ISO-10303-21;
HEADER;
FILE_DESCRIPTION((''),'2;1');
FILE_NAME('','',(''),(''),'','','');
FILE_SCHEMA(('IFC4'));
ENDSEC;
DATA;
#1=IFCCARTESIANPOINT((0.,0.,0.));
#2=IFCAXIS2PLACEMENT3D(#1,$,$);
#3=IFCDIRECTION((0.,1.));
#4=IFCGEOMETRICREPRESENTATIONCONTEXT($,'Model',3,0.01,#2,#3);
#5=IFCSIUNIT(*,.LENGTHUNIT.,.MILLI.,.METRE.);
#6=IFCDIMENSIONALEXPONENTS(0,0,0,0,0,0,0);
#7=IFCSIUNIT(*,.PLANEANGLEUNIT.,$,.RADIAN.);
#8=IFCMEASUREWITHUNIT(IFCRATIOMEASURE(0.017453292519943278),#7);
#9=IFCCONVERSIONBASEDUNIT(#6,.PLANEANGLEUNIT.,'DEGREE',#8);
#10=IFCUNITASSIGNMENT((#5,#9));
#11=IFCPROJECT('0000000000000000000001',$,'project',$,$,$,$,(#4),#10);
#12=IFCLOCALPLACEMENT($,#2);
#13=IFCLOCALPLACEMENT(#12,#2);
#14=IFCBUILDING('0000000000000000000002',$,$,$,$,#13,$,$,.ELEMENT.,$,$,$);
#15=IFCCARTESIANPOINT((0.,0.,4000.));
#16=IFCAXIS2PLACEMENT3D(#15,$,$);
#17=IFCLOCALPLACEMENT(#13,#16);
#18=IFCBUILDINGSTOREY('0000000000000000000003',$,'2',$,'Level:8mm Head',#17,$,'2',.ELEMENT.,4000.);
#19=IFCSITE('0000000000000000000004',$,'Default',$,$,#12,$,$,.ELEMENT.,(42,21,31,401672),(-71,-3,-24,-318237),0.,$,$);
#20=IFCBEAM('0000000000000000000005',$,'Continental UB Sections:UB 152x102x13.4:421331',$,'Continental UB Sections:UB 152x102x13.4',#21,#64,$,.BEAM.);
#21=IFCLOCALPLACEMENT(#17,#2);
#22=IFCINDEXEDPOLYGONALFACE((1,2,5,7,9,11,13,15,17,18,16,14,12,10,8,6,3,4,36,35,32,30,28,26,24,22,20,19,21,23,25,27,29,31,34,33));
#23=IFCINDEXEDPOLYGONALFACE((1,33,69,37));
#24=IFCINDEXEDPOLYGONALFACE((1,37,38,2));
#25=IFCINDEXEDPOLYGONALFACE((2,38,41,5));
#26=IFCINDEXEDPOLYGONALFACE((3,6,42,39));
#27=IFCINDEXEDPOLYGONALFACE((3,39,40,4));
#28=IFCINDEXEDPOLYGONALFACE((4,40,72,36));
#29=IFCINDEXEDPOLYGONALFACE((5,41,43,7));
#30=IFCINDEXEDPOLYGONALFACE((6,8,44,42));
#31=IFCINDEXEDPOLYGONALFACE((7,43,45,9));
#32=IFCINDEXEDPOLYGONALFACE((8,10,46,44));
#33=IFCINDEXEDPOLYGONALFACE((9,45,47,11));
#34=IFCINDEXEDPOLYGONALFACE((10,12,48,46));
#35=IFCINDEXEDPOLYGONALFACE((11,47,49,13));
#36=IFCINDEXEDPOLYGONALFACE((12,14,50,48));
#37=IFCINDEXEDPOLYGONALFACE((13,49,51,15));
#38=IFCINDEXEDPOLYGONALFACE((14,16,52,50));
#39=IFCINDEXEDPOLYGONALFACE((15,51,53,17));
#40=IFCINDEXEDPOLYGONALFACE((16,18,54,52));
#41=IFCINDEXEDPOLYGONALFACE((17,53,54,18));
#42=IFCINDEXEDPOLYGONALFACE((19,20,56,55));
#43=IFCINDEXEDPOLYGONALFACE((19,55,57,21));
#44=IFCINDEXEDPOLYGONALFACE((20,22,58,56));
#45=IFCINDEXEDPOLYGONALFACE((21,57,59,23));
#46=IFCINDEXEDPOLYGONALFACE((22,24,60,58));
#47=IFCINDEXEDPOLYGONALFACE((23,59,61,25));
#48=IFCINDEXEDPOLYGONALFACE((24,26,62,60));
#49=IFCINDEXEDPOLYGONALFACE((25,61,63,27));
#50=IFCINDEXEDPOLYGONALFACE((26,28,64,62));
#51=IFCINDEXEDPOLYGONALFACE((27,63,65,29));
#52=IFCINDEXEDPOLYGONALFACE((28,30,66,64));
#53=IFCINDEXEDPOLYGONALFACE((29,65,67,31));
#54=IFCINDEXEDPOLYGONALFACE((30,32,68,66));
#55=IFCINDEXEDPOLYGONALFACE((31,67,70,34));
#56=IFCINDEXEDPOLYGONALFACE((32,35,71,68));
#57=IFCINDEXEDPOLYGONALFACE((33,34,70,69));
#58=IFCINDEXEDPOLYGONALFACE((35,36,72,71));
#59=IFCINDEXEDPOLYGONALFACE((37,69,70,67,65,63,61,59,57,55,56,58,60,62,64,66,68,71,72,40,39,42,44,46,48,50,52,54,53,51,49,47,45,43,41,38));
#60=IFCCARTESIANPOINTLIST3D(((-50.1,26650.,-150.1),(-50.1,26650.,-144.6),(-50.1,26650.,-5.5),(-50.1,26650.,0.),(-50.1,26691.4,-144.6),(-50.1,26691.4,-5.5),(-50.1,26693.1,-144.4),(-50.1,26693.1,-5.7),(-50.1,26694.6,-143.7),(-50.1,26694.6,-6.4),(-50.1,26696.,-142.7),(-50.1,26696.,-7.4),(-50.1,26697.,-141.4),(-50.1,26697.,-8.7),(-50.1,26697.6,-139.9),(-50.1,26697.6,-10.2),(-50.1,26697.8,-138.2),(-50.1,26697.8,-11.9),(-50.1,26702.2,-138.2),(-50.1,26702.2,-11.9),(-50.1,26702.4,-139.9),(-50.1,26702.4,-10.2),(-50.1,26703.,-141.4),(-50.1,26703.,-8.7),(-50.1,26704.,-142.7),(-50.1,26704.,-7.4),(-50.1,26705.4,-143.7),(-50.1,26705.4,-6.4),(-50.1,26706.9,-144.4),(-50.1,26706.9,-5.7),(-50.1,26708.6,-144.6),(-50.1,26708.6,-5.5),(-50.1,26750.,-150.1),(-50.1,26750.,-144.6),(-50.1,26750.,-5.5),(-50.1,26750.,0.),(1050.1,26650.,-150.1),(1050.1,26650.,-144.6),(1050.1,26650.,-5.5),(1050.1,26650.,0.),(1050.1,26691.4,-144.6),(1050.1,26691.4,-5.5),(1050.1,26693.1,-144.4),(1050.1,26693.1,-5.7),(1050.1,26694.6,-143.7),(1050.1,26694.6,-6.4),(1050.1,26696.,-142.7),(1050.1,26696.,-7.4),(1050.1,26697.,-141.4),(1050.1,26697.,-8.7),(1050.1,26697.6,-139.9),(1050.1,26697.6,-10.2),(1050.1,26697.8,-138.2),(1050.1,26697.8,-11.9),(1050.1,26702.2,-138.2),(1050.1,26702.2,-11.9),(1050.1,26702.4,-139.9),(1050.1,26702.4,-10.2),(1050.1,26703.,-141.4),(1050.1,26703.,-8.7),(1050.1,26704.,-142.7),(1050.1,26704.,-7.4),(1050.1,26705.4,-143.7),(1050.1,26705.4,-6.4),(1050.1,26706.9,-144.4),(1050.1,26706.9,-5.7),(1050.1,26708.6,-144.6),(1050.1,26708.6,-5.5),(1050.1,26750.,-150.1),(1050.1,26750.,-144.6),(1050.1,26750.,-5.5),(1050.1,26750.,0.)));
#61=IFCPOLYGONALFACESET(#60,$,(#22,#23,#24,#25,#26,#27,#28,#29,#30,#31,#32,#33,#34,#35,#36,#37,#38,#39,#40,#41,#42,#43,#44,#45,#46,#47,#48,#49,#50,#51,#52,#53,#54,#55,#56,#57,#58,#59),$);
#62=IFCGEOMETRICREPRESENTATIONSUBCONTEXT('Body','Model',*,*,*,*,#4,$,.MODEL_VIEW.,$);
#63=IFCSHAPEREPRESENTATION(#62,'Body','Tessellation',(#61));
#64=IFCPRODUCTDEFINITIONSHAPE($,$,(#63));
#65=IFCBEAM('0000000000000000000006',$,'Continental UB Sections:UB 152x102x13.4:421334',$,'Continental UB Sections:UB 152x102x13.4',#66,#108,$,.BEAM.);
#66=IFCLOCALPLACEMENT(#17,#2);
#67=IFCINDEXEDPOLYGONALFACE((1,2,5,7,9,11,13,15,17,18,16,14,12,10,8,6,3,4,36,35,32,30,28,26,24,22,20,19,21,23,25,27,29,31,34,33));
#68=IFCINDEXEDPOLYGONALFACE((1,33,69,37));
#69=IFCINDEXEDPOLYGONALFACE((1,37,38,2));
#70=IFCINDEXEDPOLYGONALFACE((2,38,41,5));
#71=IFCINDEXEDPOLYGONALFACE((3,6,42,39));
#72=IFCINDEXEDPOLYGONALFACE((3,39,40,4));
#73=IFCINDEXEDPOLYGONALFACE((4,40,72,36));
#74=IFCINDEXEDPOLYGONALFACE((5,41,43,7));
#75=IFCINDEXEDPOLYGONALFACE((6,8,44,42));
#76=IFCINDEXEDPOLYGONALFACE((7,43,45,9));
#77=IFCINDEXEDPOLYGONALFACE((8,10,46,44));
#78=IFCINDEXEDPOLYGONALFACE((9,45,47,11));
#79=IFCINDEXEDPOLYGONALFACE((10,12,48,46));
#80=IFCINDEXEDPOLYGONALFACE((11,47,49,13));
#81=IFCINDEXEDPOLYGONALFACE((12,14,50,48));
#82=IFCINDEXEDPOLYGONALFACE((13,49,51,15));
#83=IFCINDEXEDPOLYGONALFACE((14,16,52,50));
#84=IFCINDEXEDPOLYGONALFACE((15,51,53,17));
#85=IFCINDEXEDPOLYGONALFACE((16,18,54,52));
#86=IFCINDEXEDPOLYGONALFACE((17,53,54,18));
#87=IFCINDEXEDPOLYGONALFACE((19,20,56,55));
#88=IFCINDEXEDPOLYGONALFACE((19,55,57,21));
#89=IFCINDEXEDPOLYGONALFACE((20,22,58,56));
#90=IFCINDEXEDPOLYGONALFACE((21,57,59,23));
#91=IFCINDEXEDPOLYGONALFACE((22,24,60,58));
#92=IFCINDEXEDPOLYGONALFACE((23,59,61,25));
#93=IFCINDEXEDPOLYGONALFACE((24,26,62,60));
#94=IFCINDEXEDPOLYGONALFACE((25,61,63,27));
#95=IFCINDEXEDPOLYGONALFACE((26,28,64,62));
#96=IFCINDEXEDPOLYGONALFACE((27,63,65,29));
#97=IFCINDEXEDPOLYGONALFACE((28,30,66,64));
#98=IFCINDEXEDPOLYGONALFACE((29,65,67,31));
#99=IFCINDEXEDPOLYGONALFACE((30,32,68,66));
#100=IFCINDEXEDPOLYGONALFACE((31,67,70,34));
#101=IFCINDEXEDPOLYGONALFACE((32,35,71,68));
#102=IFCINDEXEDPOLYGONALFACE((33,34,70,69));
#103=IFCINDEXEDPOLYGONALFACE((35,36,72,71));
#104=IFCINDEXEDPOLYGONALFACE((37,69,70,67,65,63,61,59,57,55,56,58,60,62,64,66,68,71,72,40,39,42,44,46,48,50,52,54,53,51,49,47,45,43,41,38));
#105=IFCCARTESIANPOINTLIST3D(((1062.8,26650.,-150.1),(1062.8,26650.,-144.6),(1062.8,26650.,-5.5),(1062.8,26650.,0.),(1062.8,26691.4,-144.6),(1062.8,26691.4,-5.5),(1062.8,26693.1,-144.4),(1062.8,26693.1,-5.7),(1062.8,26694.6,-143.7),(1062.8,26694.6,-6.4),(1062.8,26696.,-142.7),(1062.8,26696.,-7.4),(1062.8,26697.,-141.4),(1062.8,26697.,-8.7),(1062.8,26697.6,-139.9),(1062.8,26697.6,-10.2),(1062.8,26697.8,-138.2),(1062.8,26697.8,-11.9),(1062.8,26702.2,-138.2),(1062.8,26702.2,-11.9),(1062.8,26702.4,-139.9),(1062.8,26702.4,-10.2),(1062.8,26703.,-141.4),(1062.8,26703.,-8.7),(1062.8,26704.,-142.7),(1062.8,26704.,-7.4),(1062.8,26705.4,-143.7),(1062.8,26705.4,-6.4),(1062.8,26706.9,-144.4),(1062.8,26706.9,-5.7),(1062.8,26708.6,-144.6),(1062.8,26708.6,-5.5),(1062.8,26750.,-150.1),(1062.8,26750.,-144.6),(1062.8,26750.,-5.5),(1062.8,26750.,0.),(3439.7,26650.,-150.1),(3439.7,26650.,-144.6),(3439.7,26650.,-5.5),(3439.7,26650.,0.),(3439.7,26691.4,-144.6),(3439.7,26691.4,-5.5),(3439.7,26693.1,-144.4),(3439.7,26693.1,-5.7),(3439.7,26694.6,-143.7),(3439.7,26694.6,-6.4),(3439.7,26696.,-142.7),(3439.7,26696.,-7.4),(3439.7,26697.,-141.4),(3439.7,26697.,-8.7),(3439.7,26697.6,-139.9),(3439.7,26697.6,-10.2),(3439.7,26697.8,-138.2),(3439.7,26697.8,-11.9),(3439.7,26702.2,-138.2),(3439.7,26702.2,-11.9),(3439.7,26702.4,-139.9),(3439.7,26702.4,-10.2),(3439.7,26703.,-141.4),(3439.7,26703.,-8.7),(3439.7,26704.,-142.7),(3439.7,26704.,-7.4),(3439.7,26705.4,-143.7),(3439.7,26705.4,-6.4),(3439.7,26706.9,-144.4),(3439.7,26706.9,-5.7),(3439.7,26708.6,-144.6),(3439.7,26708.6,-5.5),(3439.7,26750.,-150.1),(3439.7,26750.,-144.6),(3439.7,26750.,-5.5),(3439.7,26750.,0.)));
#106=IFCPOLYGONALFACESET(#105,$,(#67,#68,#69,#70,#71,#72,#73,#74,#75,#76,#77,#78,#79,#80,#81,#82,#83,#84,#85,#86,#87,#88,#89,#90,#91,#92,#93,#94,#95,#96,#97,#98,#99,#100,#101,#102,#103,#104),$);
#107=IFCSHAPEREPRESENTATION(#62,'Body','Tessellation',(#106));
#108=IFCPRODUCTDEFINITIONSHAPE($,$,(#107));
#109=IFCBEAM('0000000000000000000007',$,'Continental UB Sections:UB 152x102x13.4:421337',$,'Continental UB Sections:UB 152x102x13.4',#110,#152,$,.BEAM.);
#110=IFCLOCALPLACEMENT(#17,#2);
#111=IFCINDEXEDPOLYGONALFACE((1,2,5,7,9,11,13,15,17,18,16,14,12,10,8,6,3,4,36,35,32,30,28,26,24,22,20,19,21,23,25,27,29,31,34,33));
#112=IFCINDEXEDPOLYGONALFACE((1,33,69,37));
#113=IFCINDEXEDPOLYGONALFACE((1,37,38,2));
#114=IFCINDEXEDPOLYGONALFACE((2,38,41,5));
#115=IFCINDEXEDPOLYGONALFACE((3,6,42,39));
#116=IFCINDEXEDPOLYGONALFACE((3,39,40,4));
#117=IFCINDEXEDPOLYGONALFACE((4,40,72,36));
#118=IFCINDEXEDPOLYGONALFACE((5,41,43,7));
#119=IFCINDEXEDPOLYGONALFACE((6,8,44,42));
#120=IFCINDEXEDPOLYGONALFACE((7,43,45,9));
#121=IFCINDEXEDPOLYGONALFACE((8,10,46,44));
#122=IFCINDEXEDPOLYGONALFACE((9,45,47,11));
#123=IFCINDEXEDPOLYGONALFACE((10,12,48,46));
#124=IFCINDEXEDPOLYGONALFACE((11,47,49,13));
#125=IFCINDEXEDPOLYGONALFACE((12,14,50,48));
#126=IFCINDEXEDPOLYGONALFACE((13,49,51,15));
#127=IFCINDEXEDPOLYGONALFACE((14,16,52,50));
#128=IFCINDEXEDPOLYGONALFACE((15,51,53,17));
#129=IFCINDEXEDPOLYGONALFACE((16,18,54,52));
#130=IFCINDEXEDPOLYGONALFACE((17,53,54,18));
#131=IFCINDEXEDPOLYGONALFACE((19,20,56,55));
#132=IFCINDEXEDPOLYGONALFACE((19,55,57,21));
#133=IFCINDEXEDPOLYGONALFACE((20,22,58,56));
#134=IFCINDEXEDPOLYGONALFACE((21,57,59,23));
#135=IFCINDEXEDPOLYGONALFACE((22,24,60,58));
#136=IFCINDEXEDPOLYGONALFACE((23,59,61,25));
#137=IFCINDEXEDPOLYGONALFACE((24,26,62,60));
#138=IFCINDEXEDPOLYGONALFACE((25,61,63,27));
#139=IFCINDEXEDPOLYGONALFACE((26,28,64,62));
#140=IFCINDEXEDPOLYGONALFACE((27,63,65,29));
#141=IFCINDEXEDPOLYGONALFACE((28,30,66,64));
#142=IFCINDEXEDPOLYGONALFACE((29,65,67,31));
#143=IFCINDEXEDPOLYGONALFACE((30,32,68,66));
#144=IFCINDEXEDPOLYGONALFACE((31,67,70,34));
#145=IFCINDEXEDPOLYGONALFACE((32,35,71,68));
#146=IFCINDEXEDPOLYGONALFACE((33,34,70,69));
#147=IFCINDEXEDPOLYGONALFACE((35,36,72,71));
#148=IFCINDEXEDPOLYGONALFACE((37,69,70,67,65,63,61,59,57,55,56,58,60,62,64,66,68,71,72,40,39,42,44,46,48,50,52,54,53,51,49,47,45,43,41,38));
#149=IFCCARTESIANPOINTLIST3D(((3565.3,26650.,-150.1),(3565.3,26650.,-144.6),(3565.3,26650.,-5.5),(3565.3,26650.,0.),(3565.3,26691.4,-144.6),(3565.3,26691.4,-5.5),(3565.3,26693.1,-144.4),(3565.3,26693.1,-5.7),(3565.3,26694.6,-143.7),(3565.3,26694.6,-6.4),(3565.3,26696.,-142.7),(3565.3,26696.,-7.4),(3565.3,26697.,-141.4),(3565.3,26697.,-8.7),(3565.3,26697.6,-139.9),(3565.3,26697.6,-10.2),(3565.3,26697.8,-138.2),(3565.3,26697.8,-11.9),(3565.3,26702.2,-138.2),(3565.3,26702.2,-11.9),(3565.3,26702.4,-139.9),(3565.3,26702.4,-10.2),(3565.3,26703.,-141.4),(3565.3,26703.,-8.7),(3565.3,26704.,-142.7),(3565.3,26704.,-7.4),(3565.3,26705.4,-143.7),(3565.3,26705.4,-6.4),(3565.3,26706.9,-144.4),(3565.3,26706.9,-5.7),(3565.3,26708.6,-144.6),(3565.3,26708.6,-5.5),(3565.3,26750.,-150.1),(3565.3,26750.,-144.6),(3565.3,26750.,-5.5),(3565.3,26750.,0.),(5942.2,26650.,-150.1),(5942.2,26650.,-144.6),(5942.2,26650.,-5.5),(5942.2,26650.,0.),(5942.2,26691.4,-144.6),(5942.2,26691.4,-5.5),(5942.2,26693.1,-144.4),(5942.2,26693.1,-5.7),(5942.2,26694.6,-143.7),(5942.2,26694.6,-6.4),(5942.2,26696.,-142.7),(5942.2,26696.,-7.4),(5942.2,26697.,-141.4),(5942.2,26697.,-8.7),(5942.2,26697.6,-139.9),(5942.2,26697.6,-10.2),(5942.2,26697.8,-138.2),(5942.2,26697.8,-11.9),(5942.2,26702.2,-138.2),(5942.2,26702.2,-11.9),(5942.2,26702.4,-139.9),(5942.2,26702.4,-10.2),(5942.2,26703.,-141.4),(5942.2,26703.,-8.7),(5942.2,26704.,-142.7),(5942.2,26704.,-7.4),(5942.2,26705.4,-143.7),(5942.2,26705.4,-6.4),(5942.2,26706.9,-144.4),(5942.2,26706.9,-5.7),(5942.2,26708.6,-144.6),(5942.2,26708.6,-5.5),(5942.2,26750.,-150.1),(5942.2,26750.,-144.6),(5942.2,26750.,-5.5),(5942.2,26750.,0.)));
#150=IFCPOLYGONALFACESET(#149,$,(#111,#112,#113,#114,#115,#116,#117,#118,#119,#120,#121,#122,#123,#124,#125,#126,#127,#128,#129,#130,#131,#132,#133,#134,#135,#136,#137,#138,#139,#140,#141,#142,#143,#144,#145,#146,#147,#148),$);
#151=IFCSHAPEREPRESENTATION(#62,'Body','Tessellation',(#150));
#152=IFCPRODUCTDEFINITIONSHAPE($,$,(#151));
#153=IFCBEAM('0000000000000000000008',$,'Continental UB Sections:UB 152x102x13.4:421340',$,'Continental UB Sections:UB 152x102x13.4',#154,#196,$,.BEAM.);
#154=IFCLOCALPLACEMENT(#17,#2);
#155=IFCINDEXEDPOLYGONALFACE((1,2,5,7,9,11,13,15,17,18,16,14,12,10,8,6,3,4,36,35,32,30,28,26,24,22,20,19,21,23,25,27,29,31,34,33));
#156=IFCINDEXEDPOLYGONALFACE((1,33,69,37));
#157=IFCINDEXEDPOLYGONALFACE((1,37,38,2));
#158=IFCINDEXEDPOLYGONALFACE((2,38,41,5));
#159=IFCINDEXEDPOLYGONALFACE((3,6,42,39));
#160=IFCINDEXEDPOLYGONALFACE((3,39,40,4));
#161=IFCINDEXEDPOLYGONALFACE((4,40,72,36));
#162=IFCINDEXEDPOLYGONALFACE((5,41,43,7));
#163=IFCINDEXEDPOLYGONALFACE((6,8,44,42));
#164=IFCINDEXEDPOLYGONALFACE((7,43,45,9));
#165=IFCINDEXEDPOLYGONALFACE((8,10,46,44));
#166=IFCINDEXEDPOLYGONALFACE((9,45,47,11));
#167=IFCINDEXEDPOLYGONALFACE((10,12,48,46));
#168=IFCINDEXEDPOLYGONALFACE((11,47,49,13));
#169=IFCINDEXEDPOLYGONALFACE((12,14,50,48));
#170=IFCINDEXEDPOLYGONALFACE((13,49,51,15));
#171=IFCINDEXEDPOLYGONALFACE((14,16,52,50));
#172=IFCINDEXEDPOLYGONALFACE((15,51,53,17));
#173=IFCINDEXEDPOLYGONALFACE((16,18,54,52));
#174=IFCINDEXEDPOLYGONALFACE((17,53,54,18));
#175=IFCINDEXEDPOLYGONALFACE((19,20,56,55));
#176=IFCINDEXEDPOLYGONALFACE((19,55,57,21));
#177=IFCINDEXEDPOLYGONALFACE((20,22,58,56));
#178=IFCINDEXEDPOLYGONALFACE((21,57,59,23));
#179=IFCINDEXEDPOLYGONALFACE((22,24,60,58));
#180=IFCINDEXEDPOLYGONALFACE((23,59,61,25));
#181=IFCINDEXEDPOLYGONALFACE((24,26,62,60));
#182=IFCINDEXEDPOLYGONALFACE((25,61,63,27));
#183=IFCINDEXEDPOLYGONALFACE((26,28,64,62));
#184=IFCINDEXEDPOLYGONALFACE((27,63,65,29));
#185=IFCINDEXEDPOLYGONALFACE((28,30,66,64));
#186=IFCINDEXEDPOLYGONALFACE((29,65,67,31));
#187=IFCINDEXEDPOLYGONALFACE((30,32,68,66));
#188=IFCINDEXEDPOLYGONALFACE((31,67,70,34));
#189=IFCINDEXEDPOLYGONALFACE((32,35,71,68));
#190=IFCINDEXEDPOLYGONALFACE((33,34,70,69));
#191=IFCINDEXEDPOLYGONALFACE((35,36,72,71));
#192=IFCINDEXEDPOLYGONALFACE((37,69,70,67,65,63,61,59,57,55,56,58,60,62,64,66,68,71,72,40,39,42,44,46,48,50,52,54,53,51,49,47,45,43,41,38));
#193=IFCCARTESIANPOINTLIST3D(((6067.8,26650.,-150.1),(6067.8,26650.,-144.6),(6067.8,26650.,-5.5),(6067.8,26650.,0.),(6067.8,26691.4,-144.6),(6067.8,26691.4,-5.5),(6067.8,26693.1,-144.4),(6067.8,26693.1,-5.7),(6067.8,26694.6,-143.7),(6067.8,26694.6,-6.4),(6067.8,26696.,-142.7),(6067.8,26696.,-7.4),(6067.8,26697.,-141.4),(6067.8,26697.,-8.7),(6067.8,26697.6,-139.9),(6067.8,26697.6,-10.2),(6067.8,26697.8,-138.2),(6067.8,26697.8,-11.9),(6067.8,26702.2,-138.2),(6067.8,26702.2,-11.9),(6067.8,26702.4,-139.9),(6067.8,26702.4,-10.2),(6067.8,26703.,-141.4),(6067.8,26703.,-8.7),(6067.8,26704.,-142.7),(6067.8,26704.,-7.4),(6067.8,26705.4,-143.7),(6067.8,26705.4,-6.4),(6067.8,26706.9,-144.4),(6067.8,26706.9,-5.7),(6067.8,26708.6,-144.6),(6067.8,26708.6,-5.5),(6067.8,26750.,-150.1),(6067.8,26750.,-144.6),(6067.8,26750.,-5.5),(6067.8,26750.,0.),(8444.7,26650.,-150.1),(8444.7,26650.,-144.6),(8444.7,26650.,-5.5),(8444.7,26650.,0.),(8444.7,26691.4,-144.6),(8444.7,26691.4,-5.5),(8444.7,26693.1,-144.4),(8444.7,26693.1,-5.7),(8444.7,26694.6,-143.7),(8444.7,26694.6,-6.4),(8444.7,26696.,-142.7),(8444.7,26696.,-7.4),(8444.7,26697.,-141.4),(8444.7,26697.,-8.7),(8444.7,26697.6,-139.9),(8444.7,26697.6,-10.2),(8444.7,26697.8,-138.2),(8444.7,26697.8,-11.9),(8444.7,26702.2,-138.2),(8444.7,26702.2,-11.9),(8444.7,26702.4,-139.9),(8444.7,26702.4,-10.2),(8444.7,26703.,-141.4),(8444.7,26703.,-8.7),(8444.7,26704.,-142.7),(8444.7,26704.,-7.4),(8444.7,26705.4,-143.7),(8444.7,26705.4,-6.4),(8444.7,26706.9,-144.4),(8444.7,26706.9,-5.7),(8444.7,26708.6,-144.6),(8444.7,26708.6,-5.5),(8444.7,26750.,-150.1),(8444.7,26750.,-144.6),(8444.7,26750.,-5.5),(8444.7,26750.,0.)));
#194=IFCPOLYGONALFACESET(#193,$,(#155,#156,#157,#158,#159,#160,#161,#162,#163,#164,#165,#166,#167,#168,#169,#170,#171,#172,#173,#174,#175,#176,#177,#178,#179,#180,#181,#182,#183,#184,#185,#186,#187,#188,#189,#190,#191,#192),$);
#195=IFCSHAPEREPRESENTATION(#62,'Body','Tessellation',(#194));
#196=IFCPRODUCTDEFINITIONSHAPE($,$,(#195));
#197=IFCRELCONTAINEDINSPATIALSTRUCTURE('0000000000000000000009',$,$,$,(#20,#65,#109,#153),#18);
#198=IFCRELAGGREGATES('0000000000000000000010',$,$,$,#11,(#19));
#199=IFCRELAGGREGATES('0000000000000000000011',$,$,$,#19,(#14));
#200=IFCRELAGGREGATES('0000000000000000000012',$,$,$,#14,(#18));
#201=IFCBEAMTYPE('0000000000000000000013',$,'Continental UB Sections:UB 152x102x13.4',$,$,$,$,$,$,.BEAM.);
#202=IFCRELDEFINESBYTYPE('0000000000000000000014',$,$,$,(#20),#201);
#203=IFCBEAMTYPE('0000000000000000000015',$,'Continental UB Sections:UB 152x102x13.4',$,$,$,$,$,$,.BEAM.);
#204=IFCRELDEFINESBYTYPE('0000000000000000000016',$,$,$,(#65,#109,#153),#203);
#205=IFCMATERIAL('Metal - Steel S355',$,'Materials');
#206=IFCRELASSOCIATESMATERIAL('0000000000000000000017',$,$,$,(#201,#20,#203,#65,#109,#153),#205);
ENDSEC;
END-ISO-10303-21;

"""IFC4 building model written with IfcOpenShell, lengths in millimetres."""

from ifc_helpers import new_model, entity, si_unit, converted_unit, direction, frame, origin, place, context, subcontext, project, spatial, line, arc, indexed_curve, outline, extrude, source, transform, mapped, material, type_object, type_shapes, element, save


model = new_model("IFC4")

# Units and contexts
model_context = context("Model", 3, precision=0.01, world=origin(), true_north=direction((0.0, 1.0)))
body_context = subcontext(model_context, "Body", "Model", "MODEL_VIEW")
ifc_project = project(units=[si_unit("LENGTHUNIT", "METRE", prefix="MILLI"), converted_unit("PLANEANGLEUNIT", "DEGREE", entity("IfcRatioMeasure", 0.017453292519943278), si_unit("PLANEANGLEUNIT", "RADIAN"), dimensions=[0, 0, 0, 0, 0, 0, 0])], contexts=[model_context])

# Site, building, storey
site_placement = place(None, origin())
site = spatial("IfcSite", under=ifc_project, at=site_placement, Name="Default", CompositionType="ELEMENT", RefLatitude=(42, 21, 31, 401672), RefLongitude=(-71, -3, -24, -318237), RefElevation=0.0)
building_placement = place(site_placement, origin())
building = spatial("IfcBuilding", under=site, at=building_placement, CompositionType="ELEMENT")
storey_placement = place(building_placement, frame((0.0, 0.0, 4000.0)))
storey = spatial("IfcBuildingStorey", under=building, at=storey_placement, Name="2", ObjectType="Level:8mm Head", LongName="2", CompositionType="ELEMENT", Elevation=4000.0)

# Beams
ifc_material_1 = material(Name="Metal - Steel S355", Category="Materials")
beam_type_1 = type_object("IfcBeamType", Name="Continental UB Sections:UB 152x102x13.4", PredefinedType="BEAM", material=ifc_material_1)
shared_shape_1 = source(origin(), body_context, "Body", "SweptSolid", [
    extrude(outline(indexed_curve([(-75.0, -50.1), (-69.6, -50.1), (-69.6, -8.5), (-67.7, -4.0), (-63.2, -2.1), (63.1, -2.1), (67.7, -4.0), (69.5, -8.5), (69.5, -50.1), (75.1, -50.1), (75.1, 50.1), (69.5, 50.1), (69.5, 8.6), (67.7, 4.0), (63.1, 2.2), (-63.2, 2.2), (-67.7, 4.0), (-69.6, 8.6), (-69.6, 50.0), (-75.0, 50.0)], segments=[line(1, 2, 3), arc(3, 4, 5), line(5, 6), arc(6, 7, 8), line(8, 9, 10, 11, 12, 13), arc(13, 14, 15), line(15, 16), arc(16, 17, 18), line(18, 19, 20, 1)], self_intersect=False)), frame((-550.1, 0.0, 0.0), z_axis=(1.0, 0.0, 0.0), x_axis=(0.0, 0.0, -1.0)), (0.0, 0.0, 1.0), 1100.2),
])
type_shapes(beam_type_1, [shared_shape_1])
beam_1_placement = place(storey_placement, frame((500.0, 26700.0, -75.1)))
element("IfcBeam", 1, at=beam_1_placement, inside=storey, type_object=beam_type_1, material=ifc_material_1, Name="Continental UB Sections:UB 152x102x13.4:421331", ObjectType="Continental UB Sections:UB 152x102x13.4", PredefinedType="BEAM", context=body_context, shape_type="MappedRepresentation", body=[
    mapped(shared_shape_1, transform((0.0, 0.0, 0.0), scale=1.0)),
])
beam_type_2 = type_object("IfcBeamType", Name="Continental UB Sections:UB 152x102x13.4", PredefinedType="BEAM", material=ifc_material_1)
shared_shape_2 = source(origin(), body_context, "Body", "SweptSolid", [
    extrude(outline(indexed_curve([(-75.0, -50.1), (-69.6, -50.1), (-69.6, -8.5), (-67.7, -4.0), (-63.2, -2.1), (63.1, -2.1), (67.7, -4.0), (69.5, -8.5), (69.5, -50.1), (75.1, -50.1), (75.1, 50.1), (69.5, 50.1), (69.5, 8.6), (67.7, 4.0), (63.1, 2.2), (-63.2, 2.2), (-67.7, 4.0), (-69.6, 8.6), (-69.6, 50.0), (-75.0, 50.0)], segments=[line(1, 2, 3), arc(3, 4, 5), line(5, 6), arc(6, 7, 8), line(8, 9, 10, 11, 12, 13), arc(13, 14, 15), line(15, 16), arc(16, 17, 18), line(18, 19, 20, 1)], self_intersect=False)), frame((-1188.4, 0.0, 0.0), z_axis=(1.0, 0.0, 0.0), x_axis=(0.0, 0.0, -1.0)), (0.0, 0.0, 1.0), 2376.9),
])
type_shapes(beam_type_2, [shared_shape_2])
for number, where, name in (
    (2, (2251.3, 26700.0, -75.1), "Continental UB Sections:UB 152x102x13.4:421334"),
    (3, (4753.8, 26700.0, -75.1), "Continental UB Sections:UB 152x102x13.4:421337"),
    (4, (7256.3, 26700.0, -75.1), "Continental UB Sections:UB 152x102x13.4:421340"),
):
    element("IfcBeam", number, at=place(storey_placement, frame(where)), inside=storey, type_object=beam_type_2, material=ifc_material_1, Name=name, ObjectType="Continental UB Sections:UB 152x102x13.4", PredefinedType="BEAM", context=body_context, shape_type="MappedRepresentation", body=[
        mapped(shared_shape_2, transform((0.0, 0.0, 0.0), scale=1.0)),
    ])

save(model, "model.ifc")
